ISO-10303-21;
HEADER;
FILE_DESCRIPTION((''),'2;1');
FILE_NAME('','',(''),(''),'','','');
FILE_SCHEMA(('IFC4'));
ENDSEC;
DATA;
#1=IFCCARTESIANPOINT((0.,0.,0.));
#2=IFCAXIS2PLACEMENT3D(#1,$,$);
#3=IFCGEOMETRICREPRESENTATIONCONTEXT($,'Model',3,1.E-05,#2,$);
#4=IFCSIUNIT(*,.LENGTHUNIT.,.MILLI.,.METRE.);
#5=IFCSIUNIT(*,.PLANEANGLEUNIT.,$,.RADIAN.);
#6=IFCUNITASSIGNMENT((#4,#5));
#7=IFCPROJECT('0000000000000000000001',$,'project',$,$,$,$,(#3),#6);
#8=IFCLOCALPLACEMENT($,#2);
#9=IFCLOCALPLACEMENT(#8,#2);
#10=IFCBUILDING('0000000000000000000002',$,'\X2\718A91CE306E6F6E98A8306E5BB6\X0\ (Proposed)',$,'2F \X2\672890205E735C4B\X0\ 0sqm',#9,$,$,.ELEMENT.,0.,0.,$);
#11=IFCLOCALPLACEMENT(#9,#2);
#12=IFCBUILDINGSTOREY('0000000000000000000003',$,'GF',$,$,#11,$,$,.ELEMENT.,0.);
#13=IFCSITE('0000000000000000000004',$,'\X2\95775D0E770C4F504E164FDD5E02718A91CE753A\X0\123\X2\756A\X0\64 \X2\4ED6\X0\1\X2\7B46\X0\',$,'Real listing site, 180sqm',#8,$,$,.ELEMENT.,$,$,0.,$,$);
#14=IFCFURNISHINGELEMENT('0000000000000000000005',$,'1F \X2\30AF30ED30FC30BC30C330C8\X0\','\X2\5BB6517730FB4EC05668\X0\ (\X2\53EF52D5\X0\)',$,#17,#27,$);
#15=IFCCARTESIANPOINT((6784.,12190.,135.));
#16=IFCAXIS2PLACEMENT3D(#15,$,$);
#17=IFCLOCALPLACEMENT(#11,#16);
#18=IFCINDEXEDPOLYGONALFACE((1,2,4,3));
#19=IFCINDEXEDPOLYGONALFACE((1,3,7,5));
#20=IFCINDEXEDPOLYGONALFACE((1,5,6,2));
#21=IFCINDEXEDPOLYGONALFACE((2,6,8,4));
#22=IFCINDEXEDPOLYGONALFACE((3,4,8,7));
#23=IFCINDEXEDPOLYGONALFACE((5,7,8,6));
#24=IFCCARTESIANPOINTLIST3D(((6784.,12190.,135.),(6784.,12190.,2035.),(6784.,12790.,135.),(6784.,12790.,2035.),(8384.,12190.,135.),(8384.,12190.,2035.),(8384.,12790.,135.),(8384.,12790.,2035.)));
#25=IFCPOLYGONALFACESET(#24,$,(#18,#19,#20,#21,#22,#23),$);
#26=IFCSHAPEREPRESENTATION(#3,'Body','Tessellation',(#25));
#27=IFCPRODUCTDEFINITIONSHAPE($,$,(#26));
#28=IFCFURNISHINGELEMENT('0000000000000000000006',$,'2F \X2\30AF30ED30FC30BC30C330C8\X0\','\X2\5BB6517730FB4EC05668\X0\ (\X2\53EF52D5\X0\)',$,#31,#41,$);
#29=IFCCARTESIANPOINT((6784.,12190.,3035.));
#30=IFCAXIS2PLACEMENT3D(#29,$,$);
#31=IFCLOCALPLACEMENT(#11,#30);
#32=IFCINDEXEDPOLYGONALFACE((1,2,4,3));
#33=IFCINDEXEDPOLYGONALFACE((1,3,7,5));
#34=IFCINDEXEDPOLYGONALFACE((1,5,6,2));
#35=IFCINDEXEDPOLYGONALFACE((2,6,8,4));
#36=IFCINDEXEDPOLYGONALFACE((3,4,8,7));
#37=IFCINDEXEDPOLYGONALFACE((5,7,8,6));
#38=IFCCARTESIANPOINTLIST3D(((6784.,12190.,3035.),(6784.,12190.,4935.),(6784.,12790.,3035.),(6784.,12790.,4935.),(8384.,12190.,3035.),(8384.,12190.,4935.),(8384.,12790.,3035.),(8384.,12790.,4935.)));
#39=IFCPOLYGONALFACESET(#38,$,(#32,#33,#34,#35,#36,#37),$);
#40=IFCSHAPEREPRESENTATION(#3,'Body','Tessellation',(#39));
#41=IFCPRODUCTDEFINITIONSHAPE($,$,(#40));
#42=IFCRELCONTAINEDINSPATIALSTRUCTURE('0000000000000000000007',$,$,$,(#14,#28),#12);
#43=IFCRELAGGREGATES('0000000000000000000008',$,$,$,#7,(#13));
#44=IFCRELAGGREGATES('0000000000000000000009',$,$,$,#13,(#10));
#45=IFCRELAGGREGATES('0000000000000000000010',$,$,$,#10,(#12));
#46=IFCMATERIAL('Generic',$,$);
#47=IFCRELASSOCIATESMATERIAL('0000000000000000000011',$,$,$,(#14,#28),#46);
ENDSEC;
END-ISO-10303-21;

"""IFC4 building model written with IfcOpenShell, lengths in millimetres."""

from ifc_helpers import new_model, si_unit, frame, frame_2d, origin, place, context, project, spatial, rectangle, extrude, material, element, save


model = new_model("IFC4")

# Units and contexts
model_context = context("Model", 3, precision=1e-05, world=origin())
ifc_project = project(units=[si_unit("LENGTHUNIT", "METRE", prefix="MILLI"), si_unit("PLANEANGLEUNIT", "RADIAN")], contexts=[model_context])

# Site, building, storey
site_placement = place(None, origin())
site = spatial("IfcSite", under=ifc_project, at=site_placement, Name="長崎県佐世保市熊野町123番64 他1筆", ObjectType="Real listing site, 180sqm", CompositionType="ELEMENT", RefElevation=0.0)
building_placement = place(site_placement, origin())
building = spatial("IfcBuilding", under=site, at=building_placement, Name="熊野の潮風の家 (Proposed)", ObjectType="2F 木造平屋 0sqm", CompositionType="ELEMENT", ElevationOfRefHeight=0.0, ElevationOfTerrain=0.0)
storey_placement = place(building_placement, origin())
storey = spatial("IfcBuildingStorey", under=building, at=storey_placement, Name="GF", CompositionType="ELEMENT", Elevation=0.0)

# Shared definitions
ifc_material_1 = material(Name="Generic")

# Furnishing elements
furnishing_1_placement = place(storey_placement, frame((6784.0, 12190.0, 135.0)))
element("IfcFurnishingElement", 1, at=furnishing_1_placement, inside=storey, material=ifc_material_1, Name="1F クローゼット", Description="家具・什器 (可動)", context=model_context, shape_type="SweptSolid", body=[
    extrude(rectangle(XDim=1600.0, YDim=600.0, at=frame_2d((800.0, 300.0))), frame((6784.0, 12190.0, 135.0)), (0.0, 0.0, 1.0), 1900.0),
])
furnishing_2_placement = place(storey_placement, frame((6784.0, 12190.0, 3035.0)))
element("IfcFurnishingElement", 2, at=furnishing_2_placement, inside=storey, material=ifc_material_1, Name="2F クローゼット", Description="家具・什器 (可動)", context=model_context, shape_type="SweptSolid", body=[
    extrude(rectangle(XDim=1600.0, YDim=600.0, at=frame_2d((800.0, 300.0))), frame((6784.0, 12190.0, 3035.0)), (0.0, 0.0, 1.0), 1900.0),
])

save(model, "model.ifc")
